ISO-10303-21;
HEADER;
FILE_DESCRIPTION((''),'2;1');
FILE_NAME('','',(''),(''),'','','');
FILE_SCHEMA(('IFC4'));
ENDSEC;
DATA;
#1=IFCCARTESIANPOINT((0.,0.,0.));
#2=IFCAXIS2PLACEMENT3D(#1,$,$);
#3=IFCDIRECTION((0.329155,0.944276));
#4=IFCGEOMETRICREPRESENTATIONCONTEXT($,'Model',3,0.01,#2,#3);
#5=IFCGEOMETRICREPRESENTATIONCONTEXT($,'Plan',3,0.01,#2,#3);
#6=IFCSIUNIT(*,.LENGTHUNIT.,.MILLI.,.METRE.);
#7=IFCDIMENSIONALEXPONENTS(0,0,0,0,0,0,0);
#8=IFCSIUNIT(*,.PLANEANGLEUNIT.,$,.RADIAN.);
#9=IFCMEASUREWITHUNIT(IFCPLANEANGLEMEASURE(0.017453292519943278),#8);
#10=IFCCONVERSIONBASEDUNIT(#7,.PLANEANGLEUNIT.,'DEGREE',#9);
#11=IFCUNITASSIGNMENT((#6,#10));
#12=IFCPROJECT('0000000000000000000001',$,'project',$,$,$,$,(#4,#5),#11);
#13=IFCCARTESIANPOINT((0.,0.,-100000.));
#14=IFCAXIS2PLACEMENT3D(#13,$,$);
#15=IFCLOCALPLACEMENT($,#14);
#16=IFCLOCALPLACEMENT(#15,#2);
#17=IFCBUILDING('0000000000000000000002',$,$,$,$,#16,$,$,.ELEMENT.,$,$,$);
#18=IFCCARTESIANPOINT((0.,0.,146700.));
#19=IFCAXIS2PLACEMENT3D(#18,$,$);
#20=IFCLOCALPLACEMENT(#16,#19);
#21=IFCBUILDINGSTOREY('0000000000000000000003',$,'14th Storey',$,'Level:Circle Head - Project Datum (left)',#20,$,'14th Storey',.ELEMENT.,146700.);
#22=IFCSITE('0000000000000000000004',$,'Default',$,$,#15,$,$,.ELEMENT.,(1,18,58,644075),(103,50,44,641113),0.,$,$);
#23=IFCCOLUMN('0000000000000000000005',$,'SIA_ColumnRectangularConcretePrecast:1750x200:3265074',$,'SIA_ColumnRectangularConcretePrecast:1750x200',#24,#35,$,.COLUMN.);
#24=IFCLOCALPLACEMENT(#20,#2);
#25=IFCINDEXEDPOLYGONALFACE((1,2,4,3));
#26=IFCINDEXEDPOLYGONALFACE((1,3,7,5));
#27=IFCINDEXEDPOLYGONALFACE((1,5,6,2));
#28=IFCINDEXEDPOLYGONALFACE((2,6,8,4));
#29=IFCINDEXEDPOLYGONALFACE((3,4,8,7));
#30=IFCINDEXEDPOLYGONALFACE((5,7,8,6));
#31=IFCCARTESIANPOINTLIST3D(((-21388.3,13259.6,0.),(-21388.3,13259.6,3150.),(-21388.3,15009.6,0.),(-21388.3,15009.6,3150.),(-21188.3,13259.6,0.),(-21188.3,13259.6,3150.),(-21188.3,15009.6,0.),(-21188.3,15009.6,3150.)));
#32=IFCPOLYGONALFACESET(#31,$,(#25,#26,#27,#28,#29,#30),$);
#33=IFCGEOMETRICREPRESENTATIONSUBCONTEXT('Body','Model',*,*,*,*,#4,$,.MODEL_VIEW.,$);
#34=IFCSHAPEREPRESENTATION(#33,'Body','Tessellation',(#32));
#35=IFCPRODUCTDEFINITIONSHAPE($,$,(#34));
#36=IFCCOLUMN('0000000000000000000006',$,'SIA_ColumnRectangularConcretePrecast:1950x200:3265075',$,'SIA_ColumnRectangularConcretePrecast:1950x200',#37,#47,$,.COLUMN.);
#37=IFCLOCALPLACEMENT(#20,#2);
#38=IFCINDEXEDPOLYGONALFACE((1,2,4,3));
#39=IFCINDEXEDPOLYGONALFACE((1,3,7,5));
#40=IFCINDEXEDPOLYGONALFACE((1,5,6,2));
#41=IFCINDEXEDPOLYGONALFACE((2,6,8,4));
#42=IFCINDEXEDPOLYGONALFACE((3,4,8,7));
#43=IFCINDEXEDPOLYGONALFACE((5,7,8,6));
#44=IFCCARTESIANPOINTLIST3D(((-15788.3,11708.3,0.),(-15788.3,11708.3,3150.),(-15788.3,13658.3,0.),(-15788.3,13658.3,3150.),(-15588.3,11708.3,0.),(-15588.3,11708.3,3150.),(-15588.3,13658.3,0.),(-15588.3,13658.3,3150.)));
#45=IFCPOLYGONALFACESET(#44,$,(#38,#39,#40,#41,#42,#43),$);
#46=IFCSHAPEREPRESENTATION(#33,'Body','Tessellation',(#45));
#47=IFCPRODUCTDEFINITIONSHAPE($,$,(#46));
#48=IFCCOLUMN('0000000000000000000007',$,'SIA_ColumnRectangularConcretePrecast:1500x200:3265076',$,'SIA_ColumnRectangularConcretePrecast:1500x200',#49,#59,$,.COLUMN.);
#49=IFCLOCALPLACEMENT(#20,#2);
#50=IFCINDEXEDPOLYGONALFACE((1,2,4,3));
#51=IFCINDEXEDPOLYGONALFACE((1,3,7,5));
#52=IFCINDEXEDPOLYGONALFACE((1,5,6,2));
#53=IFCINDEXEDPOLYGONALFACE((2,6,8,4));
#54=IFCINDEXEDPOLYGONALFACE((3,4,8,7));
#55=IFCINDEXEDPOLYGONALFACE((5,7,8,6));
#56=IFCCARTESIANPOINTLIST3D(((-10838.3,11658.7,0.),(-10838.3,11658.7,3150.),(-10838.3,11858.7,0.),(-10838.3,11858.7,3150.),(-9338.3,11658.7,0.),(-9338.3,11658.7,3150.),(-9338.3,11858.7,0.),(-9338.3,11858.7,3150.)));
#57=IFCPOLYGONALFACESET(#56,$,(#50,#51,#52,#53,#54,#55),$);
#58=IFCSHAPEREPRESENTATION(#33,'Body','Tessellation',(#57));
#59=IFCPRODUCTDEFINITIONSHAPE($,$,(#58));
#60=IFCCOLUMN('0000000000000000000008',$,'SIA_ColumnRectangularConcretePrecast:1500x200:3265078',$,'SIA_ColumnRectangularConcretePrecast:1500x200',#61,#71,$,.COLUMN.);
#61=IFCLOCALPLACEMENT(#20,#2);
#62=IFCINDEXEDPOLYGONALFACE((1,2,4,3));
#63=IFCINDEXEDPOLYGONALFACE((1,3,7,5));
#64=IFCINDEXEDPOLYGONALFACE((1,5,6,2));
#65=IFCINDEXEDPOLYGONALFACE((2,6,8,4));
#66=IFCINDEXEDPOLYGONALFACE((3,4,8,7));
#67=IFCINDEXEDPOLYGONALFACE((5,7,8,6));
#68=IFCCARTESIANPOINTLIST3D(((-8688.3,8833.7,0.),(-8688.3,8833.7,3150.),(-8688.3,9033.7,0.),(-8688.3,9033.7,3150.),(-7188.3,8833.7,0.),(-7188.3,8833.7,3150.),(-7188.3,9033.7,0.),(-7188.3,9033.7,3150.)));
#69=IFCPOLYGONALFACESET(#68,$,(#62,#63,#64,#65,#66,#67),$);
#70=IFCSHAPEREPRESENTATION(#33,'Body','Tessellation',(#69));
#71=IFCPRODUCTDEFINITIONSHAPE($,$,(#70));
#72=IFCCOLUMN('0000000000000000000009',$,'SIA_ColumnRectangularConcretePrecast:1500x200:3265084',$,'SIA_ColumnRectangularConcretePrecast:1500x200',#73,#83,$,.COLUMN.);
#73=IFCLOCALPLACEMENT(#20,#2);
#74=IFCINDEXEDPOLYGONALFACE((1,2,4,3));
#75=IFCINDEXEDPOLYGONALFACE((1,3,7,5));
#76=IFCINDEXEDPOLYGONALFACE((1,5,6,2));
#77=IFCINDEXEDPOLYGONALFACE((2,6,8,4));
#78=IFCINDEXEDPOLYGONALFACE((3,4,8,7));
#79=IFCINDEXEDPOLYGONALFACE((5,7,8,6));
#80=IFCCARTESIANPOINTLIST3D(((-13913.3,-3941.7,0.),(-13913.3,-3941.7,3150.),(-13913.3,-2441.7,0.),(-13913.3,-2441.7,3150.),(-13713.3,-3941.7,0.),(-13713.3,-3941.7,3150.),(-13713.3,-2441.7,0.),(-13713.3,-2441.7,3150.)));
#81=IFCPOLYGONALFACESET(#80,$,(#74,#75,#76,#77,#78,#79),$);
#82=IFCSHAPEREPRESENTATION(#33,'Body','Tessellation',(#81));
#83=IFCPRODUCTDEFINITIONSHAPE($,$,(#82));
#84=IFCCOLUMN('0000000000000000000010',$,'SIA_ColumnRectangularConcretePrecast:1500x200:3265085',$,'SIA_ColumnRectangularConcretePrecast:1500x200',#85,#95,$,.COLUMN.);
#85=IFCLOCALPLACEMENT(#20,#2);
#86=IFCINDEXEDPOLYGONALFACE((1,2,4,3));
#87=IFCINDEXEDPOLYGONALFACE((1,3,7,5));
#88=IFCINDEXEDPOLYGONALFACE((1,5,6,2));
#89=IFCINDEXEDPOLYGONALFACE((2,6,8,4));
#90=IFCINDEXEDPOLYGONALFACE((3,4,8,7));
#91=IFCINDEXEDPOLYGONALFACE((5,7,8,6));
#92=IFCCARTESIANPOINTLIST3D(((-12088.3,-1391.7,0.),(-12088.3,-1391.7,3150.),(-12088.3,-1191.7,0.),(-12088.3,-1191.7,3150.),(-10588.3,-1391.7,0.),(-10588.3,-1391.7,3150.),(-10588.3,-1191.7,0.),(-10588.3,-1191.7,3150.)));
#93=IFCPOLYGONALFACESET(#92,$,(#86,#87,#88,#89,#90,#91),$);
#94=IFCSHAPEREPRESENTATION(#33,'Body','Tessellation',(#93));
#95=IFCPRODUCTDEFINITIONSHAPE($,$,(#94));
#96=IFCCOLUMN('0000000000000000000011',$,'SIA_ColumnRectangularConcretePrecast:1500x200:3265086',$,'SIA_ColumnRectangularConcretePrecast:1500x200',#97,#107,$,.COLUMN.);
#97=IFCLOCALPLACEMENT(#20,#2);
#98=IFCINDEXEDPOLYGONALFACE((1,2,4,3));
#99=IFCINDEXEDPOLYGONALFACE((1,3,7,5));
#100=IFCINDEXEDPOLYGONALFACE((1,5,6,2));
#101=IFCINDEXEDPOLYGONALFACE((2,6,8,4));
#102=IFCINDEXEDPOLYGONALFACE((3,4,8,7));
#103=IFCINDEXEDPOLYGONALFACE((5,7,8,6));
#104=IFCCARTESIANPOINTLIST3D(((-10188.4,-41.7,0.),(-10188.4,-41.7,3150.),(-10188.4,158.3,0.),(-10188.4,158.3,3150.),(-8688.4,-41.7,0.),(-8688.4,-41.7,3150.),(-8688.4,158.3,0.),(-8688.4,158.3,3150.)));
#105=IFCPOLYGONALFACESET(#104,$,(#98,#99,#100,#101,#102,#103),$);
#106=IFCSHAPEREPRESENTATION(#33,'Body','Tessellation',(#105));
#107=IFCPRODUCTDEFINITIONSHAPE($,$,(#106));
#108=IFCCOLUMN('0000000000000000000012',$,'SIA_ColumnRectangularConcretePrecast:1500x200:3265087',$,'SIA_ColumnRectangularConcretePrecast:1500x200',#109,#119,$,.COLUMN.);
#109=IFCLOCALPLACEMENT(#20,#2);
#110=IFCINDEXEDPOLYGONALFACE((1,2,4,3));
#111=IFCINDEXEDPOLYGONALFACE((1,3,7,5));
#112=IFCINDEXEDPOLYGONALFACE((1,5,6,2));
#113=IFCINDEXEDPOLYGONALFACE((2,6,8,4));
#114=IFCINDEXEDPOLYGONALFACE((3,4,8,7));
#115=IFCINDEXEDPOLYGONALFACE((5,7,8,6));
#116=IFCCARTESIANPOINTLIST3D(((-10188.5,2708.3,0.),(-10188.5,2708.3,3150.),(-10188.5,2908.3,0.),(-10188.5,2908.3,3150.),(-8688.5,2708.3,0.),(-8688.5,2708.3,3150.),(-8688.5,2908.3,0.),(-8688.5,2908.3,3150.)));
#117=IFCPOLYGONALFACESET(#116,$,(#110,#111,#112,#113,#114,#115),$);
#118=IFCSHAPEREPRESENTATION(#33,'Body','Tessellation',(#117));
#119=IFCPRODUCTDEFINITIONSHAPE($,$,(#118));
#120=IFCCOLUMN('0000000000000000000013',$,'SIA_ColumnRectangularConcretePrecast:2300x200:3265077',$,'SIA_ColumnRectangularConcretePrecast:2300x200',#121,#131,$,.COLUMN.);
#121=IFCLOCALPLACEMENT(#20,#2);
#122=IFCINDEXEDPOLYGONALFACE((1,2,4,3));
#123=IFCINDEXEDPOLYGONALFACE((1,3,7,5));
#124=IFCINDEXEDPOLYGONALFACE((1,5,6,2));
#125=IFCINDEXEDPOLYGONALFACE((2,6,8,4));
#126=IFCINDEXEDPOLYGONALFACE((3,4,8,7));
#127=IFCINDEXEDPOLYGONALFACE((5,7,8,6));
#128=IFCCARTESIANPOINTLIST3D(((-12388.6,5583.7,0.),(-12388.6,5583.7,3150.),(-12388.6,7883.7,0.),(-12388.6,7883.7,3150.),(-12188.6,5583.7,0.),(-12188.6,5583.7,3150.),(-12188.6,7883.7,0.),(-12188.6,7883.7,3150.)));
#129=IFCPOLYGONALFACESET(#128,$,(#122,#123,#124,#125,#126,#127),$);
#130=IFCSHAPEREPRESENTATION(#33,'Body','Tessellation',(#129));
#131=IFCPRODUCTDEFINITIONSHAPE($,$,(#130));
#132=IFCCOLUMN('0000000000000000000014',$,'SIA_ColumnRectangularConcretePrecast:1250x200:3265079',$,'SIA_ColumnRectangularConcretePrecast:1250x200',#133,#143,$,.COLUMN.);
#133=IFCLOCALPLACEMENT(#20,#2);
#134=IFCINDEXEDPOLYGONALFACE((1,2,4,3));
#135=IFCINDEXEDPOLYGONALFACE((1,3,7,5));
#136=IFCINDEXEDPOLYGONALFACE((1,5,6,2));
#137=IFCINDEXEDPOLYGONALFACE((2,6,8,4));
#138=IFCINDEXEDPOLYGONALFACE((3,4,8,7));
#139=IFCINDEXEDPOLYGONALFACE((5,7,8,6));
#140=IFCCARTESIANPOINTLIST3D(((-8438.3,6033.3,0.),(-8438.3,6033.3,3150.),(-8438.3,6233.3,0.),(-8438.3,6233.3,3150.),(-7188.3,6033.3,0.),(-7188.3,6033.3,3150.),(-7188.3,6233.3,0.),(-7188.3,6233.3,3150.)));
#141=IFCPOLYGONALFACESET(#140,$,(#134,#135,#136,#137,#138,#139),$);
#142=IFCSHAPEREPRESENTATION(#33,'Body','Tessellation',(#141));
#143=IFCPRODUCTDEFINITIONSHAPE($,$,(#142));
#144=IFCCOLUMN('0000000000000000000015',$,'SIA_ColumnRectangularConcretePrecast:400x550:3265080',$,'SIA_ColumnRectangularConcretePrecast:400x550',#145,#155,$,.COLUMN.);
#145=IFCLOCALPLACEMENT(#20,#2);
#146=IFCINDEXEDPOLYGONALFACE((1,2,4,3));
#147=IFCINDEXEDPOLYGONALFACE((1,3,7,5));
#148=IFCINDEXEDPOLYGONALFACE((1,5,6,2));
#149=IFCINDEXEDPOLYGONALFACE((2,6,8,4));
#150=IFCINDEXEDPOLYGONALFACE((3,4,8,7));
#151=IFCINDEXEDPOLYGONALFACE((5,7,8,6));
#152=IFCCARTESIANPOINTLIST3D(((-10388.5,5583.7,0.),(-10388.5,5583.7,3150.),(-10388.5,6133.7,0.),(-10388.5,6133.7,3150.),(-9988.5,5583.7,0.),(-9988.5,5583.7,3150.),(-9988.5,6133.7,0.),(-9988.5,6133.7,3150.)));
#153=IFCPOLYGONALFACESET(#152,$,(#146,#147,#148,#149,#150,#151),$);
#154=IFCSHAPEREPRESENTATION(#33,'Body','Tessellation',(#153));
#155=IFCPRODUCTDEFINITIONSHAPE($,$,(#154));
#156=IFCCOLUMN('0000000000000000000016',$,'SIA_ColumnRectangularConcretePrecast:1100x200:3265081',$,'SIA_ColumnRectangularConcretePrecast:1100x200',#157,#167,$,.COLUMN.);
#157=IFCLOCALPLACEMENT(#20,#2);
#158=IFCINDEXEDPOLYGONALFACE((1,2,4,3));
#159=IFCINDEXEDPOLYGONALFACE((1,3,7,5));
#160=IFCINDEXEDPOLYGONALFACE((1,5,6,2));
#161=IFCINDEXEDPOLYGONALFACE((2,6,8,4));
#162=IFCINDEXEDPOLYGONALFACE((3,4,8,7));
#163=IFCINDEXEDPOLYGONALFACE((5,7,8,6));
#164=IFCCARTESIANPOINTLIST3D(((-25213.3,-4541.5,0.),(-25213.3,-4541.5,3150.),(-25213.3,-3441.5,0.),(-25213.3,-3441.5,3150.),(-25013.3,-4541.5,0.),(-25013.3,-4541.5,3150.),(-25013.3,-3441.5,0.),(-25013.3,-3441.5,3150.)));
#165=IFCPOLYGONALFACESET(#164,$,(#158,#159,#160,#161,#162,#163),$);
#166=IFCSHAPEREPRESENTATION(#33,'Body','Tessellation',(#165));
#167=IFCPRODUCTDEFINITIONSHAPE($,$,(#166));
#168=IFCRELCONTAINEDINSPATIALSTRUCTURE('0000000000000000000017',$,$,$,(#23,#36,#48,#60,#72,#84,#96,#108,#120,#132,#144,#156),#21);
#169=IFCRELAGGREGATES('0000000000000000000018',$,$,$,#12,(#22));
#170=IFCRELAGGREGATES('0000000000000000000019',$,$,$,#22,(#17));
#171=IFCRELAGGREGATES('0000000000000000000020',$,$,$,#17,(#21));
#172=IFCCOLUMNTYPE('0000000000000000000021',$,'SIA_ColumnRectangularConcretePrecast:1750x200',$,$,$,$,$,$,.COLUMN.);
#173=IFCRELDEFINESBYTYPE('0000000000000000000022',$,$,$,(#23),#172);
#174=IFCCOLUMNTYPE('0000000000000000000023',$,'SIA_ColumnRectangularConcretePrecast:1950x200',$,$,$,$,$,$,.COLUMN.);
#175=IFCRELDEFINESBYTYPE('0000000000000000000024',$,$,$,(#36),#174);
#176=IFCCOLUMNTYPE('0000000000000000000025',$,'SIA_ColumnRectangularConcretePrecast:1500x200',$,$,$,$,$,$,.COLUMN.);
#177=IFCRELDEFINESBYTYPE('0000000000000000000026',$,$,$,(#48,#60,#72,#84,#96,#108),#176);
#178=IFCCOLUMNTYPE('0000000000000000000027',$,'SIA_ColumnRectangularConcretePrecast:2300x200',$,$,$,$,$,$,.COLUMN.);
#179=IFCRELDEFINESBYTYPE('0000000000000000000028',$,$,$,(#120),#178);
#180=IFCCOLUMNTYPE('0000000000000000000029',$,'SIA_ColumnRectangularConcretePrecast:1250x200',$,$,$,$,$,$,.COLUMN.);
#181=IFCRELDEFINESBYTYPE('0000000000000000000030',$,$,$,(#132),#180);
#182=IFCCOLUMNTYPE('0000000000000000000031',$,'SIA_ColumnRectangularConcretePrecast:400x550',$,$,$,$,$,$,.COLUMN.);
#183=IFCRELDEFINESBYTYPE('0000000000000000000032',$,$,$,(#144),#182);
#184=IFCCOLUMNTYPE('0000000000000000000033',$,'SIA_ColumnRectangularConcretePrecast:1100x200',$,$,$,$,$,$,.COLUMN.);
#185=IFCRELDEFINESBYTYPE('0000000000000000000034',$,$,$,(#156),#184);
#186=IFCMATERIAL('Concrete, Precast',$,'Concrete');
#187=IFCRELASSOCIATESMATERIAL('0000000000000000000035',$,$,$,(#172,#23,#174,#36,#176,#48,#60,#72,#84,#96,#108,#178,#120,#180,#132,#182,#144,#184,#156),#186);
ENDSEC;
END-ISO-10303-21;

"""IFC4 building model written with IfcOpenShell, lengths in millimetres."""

from ifc_helpers import new_model, entity, si_unit, converted_unit, direction, frame, origin, place, context, subcontext, project, spatial, indexed_curve, outline, extrude, source, transform, mapped, material, type_object, type_shapes, element, save


model = new_model("IFC4")

# Units and contexts
model_context = context("Model", 3, precision=0.01, world=origin(), true_north=direction((0.329155, 0.944276)))
plan_context = context("Plan", 3, precision=0.01, world=origin(), true_north=direction((0.329155, 0.944276)))
body_context = subcontext(model_context, "Body", "Model", "MODEL_VIEW")
ifc_project = project(units=[si_unit("LENGTHUNIT", "METRE", prefix="MILLI"), converted_unit("PLANEANGLEUNIT", "DEGREE", entity("IfcPlaneAngleMeasure", 0.017453292519943278), si_unit("PLANEANGLEUNIT", "RADIAN"), dimensions=[0, 0, 0, 0, 0, 0, 0])], contexts=[model_context, plan_context])

# Site, building, storey
site_placement = place(None, frame((0.0, 0.0, -100000.0)))
site = spatial("IfcSite", under=ifc_project, at=site_placement, Name="Default", CompositionType="ELEMENT", RefLatitude=(1, 18, 58, 644075), RefLongitude=(103, 50, 44, 641113), RefElevation=0.0)
building_placement = place(site_placement, origin())
building = spatial("IfcBuilding", under=site, at=building_placement, CompositionType="ELEMENT")
storey_placement = place(building_placement, frame((0.0, 0.0, 146700.0)))
storey = spatial("IfcBuildingStorey", under=building, at=storey_placement, Name="14th Storey", ObjectType="Level:Circle Head - Project Datum (left)", LongName="14th Storey", CompositionType="ELEMENT", Elevation=146700.0)

# Columns
ifc_material_1 = material(Name="Concrete, Precast", Category="Concrete")
column_type_1 = type_object("IfcColumnType", Name="SIA_ColumnRectangularConcretePrecast:1750x200", PredefinedType="COLUMN", material=ifc_material_1)
shared_shape_1 = source(origin(), body_context, "Body", "SweptSolid", [
    extrude(outline(indexed_curve([(-100.0, -875.0), (100.0, -875.0), (100.0, 875.0), (-100.0, 875.0), (-100.0, -875.0)], self_intersect=False)), frame((0.0, 0.0, 146700.0), z_axis=(0.0, 0.0, 1.0), x_axis=(-1.0, 0.0, 0.0)), (0.0, 0.0, 1.0), 3150.0),
])
type_shapes(column_type_1, [shared_shape_1])
column_1_placement = place(storey_placement, frame((-21288.3, 14134.6, -146700.0)))
element("IfcColumn", 1, at=column_1_placement, inside=storey, type_object=column_type_1, material=ifc_material_1, Name="SIA_ColumnRectangularConcretePrecast:1750x200:3265074", ObjectType="SIA_ColumnRectangularConcretePrecast:1750x200", PredefinedType="COLUMN", context=body_context, shape_type="MappedRepresentation", body=[
    mapped(shared_shape_1, transform((0.0, 0.0, 0.0), scale=1.0)),
])
column_type_2 = type_object("IfcColumnType", Name="SIA_ColumnRectangularConcretePrecast:1950x200", PredefinedType="COLUMN", material=ifc_material_1)
shared_shape_2 = source(origin(), body_context, "Body", "SweptSolid", [
    extrude(outline(indexed_curve([(-100.0, -975.0), (100.0, -975.0), (100.0, 975.0), (-100.0, 975.0), (-100.0, -975.0)], self_intersect=False)), frame((0.0, 0.0, 146700.0), z_axis=(0.0, 0.0, 1.0), x_axis=(-1.0, 0.0, 0.0)), (0.0, 0.0, 1.0), 3150.0),
])
type_shapes(column_type_2, [shared_shape_2])
column_2_placement = place(storey_placement, frame((-15688.3, 12683.3, -146700.0)))
element("IfcColumn", 2, at=column_2_placement, inside=storey, type_object=column_type_2, material=ifc_material_1, Name="SIA_ColumnRectangularConcretePrecast:1950x200:3265075", ObjectType="SIA_ColumnRectangularConcretePrecast:1950x200", PredefinedType="COLUMN", context=body_context, shape_type="MappedRepresentation", body=[
    mapped(shared_shape_2, transform((0.0, 0.0, 0.0), scale=1.0)),
])
column_type_3 = type_object("IfcColumnType", Name="SIA_ColumnRectangularConcretePrecast:1500x200", PredefinedType="COLUMN", material=ifc_material_1)
shared_shape_3 = source(origin(), body_context, "Body", "SweptSolid", [
    extrude(outline(indexed_curve([(-100.0, -750.0), (100.0, -750.0), (100.0, 750.0), (-100.0, 750.0), (-100.0, -750.0)], self_intersect=False)), frame((0.0, 0.0, 146700.0), z_axis=(0.0, 0.0, 1.0), x_axis=(-1.0, 0.0, 0.0)), (0.0, 0.0, 1.0), 3150.0),
])
type_shapes(column_type_3, [shared_shape_3])
for number, where, z_axis, x_axis, name in (
    (3, (-10088.3, 11758.7, -146700.0), (0.0, 0.0, 1.0), (0.0, -1.0, 0.0), "SIA_ColumnRectangularConcretePrecast:1500x200:3265076"),
    (4, (-7938.3, 8933.7, -146700.0), (0.0, 0.0, 1.0), (0.0, 1.0, 0.0), "SIA_ColumnRectangularConcretePrecast:1500x200:3265078"),
):
    element("IfcColumn", number, at=place(storey_placement, frame(where, z_axis=z_axis, x_axis=x_axis)), inside=storey, type_object=column_type_3, material=ifc_material_1, Name=name, ObjectType="SIA_ColumnRectangularConcretePrecast:1500x200", PredefinedType="COLUMN", context=body_context, shape_type="MappedRepresentation", body=[
        mapped(shared_shape_3, transform((0.0, 0.0, 0.0), scale=1.0)),
    ])
column_3_placement = place(storey_placement, frame((-13813.3, -3191.7, -146700.0)))
element("IfcColumn", 5, at=column_3_placement, inside=storey, type_object=column_type_3, material=ifc_material_1, Name="SIA_ColumnRectangularConcretePrecast:1500x200:3265084", ObjectType="SIA_ColumnRectangularConcretePrecast:1500x200", PredefinedType="COLUMN", context=body_context, shape_type="MappedRepresentation", body=[
    mapped(shared_shape_3, transform((0.0, 0.0, 0.0), scale=1.0)),
])
for number, where, z_axis, x_axis, name in (
    (6, (-11338.3, -1291.7, -146700.0), (0.0, 0.0, 1.0), (0.0, -1.0, 0.0), "SIA_ColumnRectangularConcretePrecast:1500x200:3265085"),
    (7, (-9438.4, 58.3, -146700.0), (0.0, 0.0, 1.0), (0.0, -1.0, 0.0), "SIA_ColumnRectangularConcretePrecast:1500x200:3265086"),
    (8, (-9438.5, 2808.3, -146700.0), (0.0, 0.0, 1.0), (0.0, -1.0, 0.0), "SIA_ColumnRectangularConcretePrecast:1500x200:3265087"),
):
    element("IfcColumn", number, at=place(storey_placement, frame(where, z_axis=z_axis, x_axis=x_axis)), inside=storey, type_object=column_type_3, material=ifc_material_1, Name=name, ObjectType="SIA_ColumnRectangularConcretePrecast:1500x200", PredefinedType="COLUMN", context=body_context, shape_type="MappedRepresentation", body=[
        mapped(shared_shape_3, transform((0.0, 0.0, 0.0), scale=1.0)),
    ])
column_type_4 = type_object("IfcColumnType", Name="SIA_ColumnRectangularConcretePrecast:2300x200", PredefinedType="COLUMN", material=ifc_material_1)
shared_shape_4 = source(origin(), body_context, "Body", "SweptSolid", [
    extrude(outline(indexed_curve([(-100.0, -1150.0), (100.0, -1150.0), (100.0, 1150.0), (-100.0, 1150.0), (-100.0, -1150.0)], self_intersect=False)), frame((0.0, 0.0, 146700.0), z_axis=(0.0, 0.0, 1.0), x_axis=(-1.0, 0.0, 0.0)), (0.0, 0.0, 1.0), 3150.0),
])
type_shapes(column_type_4, [shared_shape_4])
column_4_placement = place(storey_placement, frame((-12288.6, 6733.7, -146700.0)))
element("IfcColumn", 9, at=column_4_placement, inside=storey, type_object=column_type_4, material=ifc_material_1, Name="SIA_ColumnRectangularConcretePrecast:2300x200:3265077", ObjectType="SIA_ColumnRectangularConcretePrecast:2300x200", PredefinedType="COLUMN", context=body_context, shape_type="MappedRepresentation", body=[
    mapped(shared_shape_4, transform((0.0, 0.0, 0.0), scale=1.0)),
])
column_type_5 = type_object("IfcColumnType", Name="SIA_ColumnRectangularConcretePrecast:1250x200", PredefinedType="COLUMN", material=ifc_material_1)
shared_shape_5 = source(origin(), body_context, "Body", "SweptSolid", [
    extrude(outline(indexed_curve([(-100.0, -625.0), (100.0, -625.0), (100.0, 625.0), (-100.0, 625.0), (-100.0, -625.0)], self_intersect=False)), frame((0.0, 0.0, 146700.0), z_axis=(0.0, 0.0, 1.0), x_axis=(-1.0, 0.0, 0.0)), (0.0, 0.0, 1.0), 3150.0),
])
type_shapes(column_type_5, [shared_shape_5])
column_5_placement = place(storey_placement, frame((-7813.3, 6133.3, -146700.0), z_axis=(0.0, 0.0, 1.0), x_axis=(0.0, 1.0, 0.0)))
element("IfcColumn", 10, at=column_5_placement, inside=storey, type_object=column_type_5, material=ifc_material_1, Name="SIA_ColumnRectangularConcretePrecast:1250x200:3265079", ObjectType="SIA_ColumnRectangularConcretePrecast:1250x200", PredefinedType="COLUMN", context=body_context, shape_type="MappedRepresentation", body=[
    mapped(shared_shape_5, transform((0.0, 0.0, 0.0), scale=1.0)),
])
column_type_6 = type_object("IfcColumnType", Name="SIA_ColumnRectangularConcretePrecast:400x550", PredefinedType="COLUMN", material=ifc_material_1)
shared_shape_6 = source(origin(), body_context, "Body", "SweptSolid", [
    extrude(outline(indexed_curve([(-275.0, -200.0), (275.0, -200.0), (275.0, 200.0), (-275.0, 200.0), (-275.0, -200.0)], self_intersect=False)), frame((0.0, 0.0, 146700.0), z_axis=(0.0, 0.0, 1.0), x_axis=(-1.0, 0.0, 0.0)), (0.0, 0.0, 1.0), 3150.0),
])
type_shapes(column_type_6, [shared_shape_6])
column_6_placement = place(storey_placement, frame((-10188.5, 5858.7, -146700.0), z_axis=(0.0, 0.0, 1.0), x_axis=(0.0, -1.0, 0.0)))
element("IfcColumn", 11, at=column_6_placement, inside=storey, type_object=column_type_6, material=ifc_material_1, Name="SIA_ColumnRectangularConcretePrecast:400x550:3265080", ObjectType="SIA_ColumnRectangularConcretePrecast:400x550", PredefinedType="COLUMN", context=body_context, shape_type="MappedRepresentation", body=[
    mapped(shared_shape_6, transform((0.0, 0.0, 0.0), scale=1.0)),
])
column_type_7 = type_object("IfcColumnType", Name="SIA_ColumnRectangularConcretePrecast:1100x200", PredefinedType="COLUMN", material=ifc_material_1)
shared_shape_7 = source(origin(), body_context, "Body", "SweptSolid", [
    extrude(outline(indexed_curve([(-100.0, -550.0), (100.0, -550.0), (100.0, 550.0), (-100.0, 550.0), (-100.0, -550.0)], self_intersect=False)), frame((0.0, 0.0, 146700.0), z_axis=(0.0, 0.0, 1.0), x_axis=(-1.0, 0.0, 0.0)), (0.0, 0.0, 1.0), 3150.0),
])
type_shapes(column_type_7, [shared_shape_7])
for number, where, name in (
    (12, (-25113.3, -3991.5, -146700.0), "SIA_ColumnRectangularConcretePrecast:1100x200:3265081"),
):
    element("IfcColumn", number, at=place(storey_placement, frame(where)), inside=storey, type_object=column_type_7, material=ifc_material_1, Name=name, ObjectType="SIA_ColumnRectangularConcretePrecast:1100x200", PredefinedType="COLUMN", context=body_context, shape_type="MappedRepresentation", body=[
        mapped(shared_shape_7, transform((0.0, 0.0, 0.0), scale=1.0)),
    ])

save(model, "model.ifc")
